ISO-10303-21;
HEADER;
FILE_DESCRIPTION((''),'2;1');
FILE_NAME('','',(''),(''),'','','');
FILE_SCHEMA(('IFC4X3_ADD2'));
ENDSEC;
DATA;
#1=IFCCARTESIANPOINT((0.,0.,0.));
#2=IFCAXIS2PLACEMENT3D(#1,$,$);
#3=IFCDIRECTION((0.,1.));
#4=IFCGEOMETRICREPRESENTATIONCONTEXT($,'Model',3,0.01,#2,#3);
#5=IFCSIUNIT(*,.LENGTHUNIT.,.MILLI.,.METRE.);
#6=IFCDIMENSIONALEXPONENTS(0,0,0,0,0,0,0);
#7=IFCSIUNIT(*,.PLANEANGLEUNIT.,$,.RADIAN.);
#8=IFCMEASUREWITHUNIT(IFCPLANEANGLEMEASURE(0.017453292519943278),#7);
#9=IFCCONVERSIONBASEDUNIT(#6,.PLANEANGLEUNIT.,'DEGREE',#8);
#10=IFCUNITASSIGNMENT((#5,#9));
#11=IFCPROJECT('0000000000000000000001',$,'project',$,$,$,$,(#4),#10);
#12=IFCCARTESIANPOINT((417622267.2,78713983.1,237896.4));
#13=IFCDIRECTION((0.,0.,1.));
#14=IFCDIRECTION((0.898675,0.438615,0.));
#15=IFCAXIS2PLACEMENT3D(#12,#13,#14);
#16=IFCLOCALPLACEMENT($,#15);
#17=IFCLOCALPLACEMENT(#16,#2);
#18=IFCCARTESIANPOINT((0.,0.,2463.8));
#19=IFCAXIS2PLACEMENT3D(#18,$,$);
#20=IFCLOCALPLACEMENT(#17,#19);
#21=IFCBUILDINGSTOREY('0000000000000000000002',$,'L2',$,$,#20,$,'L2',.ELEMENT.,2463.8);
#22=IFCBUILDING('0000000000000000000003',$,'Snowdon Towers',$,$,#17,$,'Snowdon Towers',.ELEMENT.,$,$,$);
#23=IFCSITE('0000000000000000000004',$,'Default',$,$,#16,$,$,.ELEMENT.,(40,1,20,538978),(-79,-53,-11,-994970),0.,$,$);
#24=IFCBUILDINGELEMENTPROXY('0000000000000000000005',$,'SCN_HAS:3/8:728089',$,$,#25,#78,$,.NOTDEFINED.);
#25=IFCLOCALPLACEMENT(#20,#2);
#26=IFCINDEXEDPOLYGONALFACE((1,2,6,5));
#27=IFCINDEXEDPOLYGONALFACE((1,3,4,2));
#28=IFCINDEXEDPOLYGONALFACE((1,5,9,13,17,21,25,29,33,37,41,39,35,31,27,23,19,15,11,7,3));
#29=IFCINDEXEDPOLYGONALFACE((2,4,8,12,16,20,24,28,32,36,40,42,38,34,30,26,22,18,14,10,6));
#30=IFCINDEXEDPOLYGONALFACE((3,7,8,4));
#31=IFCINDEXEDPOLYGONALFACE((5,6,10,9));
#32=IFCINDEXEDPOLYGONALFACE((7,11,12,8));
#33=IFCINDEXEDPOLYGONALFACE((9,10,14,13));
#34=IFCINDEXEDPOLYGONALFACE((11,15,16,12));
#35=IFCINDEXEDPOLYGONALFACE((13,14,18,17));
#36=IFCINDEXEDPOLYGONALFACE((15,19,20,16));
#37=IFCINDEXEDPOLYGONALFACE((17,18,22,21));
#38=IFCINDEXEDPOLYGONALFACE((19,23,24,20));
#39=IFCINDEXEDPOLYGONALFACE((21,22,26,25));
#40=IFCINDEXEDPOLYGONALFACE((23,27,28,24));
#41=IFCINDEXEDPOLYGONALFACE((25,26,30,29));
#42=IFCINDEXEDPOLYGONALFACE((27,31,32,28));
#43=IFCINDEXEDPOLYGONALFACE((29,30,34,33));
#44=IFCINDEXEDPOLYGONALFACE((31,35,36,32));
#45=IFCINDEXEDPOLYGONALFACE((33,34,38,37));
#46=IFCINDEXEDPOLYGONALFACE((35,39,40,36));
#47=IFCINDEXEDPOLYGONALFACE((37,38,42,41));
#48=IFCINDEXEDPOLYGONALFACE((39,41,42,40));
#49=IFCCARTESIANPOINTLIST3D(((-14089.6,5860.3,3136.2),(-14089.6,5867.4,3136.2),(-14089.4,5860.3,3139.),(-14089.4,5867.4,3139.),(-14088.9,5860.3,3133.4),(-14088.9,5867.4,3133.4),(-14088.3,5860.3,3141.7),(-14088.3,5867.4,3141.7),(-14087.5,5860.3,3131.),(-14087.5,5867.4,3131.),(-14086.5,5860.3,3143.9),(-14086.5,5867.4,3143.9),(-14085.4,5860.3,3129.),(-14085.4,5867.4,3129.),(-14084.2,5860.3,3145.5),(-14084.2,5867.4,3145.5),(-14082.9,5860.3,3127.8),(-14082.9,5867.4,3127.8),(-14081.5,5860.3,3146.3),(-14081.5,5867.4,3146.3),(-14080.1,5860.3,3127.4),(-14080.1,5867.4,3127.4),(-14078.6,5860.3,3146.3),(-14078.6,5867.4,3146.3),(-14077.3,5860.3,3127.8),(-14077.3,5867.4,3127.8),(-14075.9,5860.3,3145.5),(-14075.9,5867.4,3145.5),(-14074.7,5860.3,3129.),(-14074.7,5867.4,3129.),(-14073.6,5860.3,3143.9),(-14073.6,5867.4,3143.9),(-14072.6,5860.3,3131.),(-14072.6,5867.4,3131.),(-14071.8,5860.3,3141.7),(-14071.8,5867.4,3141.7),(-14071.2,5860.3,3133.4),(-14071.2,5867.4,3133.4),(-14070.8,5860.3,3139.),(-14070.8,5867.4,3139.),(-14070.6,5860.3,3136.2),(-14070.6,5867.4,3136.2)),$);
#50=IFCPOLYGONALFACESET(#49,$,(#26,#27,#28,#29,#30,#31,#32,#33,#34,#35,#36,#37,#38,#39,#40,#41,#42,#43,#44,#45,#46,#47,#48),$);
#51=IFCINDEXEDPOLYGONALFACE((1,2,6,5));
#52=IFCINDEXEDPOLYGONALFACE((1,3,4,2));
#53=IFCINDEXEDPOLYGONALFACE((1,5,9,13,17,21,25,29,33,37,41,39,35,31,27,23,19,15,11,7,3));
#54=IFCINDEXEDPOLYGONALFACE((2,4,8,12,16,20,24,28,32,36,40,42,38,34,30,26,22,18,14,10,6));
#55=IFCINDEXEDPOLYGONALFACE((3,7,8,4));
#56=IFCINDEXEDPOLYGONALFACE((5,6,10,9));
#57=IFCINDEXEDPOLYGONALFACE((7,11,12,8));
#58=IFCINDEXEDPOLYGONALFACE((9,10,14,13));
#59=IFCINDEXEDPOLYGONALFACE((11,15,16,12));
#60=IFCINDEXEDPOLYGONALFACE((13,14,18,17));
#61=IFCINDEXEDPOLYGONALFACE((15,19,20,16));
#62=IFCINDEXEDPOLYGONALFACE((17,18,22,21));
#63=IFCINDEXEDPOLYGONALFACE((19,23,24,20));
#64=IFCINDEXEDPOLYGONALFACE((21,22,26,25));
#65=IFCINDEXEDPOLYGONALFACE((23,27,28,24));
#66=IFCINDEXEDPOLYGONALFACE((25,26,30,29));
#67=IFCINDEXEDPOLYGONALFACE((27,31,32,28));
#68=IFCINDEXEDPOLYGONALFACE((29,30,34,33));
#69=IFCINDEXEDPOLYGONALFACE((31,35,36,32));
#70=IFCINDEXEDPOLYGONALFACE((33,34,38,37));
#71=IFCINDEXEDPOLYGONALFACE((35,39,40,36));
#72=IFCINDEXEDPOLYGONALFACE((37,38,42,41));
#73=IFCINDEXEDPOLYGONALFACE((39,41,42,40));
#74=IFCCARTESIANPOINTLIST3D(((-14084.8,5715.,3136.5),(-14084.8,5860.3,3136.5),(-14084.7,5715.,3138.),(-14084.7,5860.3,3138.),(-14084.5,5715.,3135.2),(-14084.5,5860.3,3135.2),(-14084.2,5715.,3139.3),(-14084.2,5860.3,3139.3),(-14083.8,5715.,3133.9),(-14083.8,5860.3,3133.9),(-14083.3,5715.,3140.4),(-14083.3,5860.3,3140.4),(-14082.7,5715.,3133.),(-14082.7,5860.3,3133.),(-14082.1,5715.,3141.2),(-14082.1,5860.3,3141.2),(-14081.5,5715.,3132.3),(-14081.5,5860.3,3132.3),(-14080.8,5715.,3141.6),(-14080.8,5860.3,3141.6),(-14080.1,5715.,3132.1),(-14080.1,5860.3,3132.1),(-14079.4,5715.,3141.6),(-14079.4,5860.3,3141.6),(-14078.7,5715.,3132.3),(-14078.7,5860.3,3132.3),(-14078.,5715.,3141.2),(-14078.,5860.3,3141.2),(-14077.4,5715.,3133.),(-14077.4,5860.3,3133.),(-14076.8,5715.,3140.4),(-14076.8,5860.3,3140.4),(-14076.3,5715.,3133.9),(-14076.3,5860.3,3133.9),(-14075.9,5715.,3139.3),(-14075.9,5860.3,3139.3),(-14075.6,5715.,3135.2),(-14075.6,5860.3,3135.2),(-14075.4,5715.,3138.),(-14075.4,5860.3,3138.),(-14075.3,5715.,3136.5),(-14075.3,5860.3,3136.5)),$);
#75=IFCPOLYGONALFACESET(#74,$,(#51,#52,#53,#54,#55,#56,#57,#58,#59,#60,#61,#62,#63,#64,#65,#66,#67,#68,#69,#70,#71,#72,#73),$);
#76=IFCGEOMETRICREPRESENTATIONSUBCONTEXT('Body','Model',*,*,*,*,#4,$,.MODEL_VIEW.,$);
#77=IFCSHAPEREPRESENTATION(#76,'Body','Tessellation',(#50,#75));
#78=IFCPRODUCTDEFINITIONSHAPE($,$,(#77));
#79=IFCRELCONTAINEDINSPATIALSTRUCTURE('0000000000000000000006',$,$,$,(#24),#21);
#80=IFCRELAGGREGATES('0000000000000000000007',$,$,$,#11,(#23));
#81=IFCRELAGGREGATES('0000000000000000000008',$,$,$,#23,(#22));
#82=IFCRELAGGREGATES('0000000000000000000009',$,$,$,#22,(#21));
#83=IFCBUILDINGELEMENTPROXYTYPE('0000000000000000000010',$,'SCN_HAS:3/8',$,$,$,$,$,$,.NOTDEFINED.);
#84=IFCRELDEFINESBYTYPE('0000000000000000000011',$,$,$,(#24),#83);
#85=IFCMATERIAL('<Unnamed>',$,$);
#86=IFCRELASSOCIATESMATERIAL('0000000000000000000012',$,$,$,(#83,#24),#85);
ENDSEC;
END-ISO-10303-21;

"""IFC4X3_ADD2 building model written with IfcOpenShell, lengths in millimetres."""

from ifc_helpers import new_model, entity, si_unit, converted_unit, direction, frame, frame_2d, origin, place, context, subcontext, project, spatial, circle, extrude, source, transform, mapped, material, type_object, type_shapes, element, save


model = new_model("IFC4X3_ADD2")

# Units and contexts
model_context = context("Model", 3, precision=0.01, world=origin(), true_north=direction((0.0, 1.0)))
body_context = subcontext(model_context, "Body", "Model", "MODEL_VIEW")
ifc_project = project(units=[si_unit("LENGTHUNIT", "METRE", prefix="MILLI"), converted_unit("PLANEANGLEUNIT", "DEGREE", entity("IfcPlaneAngleMeasure", 0.017453292519943278), si_unit("PLANEANGLEUNIT", "RADIAN"), dimensions=[0, 0, 0, 0, 0, 0, 0])], contexts=[model_context])

# Site, building, storey
site_placement = place(None, frame((417622267.2, 78713983.1, 237896.4), z_axis=(0.0, 0.0, 1.0), x_axis=(0.898675, 0.438615, 0.0)))
site = spatial("IfcSite", under=ifc_project, at=site_placement, Name="Default", CompositionType="ELEMENT", RefLatitude=(40, 1, 20, 538978), RefLongitude=(-79, -53, -11, -994970), RefElevation=0.0)
building_placement = place(site_placement, origin())
building = spatial("IfcBuilding", under=site, at=building_placement, Name="Snowdon Towers", LongName="Snowdon Towers", CompositionType="ELEMENT")
storey_placement = place(building_placement, frame((0.0, 0.0, 2463.8)))
storey = spatial("IfcBuildingStorey", under=building, at=storey_placement, Name="L2", LongName="L2", CompositionType="ELEMENT", Elevation=2463.8)

# Building element proxy
ifc_material_1 = material(Name="<Unnamed>")
building_element_proxy_type_1 = type_object("IfcBuildingElementProxyType", Name="SCN_HAS:3/8", PredefinedType="NOTDEFINED", material=ifc_material_1)
shared_shape_1 = source(origin(), body_context, "Body", "SweptSolid", [
    extrude(circle(Radius=9.5, at=frame_2d((0.0, 0.0), x_axis=(1.0, 0.0))), frame((0.0, 0.0, -152.4), z_axis=(0.0, 0.0, 1.0), x_axis=(0.0, -1.0, 0.0)), (0.0, 0.0, 1.0), 7.1),
    extrude(circle(Radius=4.8, at=frame_2d((0.0, 0.0), x_axis=(1.0, 0.0))), frame((0.0, 0.0, -145.3), z_axis=(0.0, 0.0, 1.0), x_axis=(0.0, -1.0, 0.0)), (0.0, 0.0, 1.0), 145.3),
])
type_shapes(building_element_proxy_type_1, [shared_shape_1])
for number, where, z_axis, x_axis, name in (
    (1, (-14080.1, 5715.0, 3136.9), (0.0, -1.0, 0.0), (1.0, 0.0, 0.0), "SCN_HAS:3/8:728089"),
):
    element("IfcBuildingElementProxy", number, at=place(storey_placement, frame(where, z_axis=z_axis, x_axis=x_axis)), inside=storey, type_object=building_element_proxy_type_1, material=ifc_material_1, Name=name, PredefinedType="NOTDEFINED", context=body_context, shape_type="MappedRepresentation", body=[
        mapped(shared_shape_1, transform((0.0, 0.0, 0.0), scale=1.0)),
    ])

save(model, "model.ifc")
